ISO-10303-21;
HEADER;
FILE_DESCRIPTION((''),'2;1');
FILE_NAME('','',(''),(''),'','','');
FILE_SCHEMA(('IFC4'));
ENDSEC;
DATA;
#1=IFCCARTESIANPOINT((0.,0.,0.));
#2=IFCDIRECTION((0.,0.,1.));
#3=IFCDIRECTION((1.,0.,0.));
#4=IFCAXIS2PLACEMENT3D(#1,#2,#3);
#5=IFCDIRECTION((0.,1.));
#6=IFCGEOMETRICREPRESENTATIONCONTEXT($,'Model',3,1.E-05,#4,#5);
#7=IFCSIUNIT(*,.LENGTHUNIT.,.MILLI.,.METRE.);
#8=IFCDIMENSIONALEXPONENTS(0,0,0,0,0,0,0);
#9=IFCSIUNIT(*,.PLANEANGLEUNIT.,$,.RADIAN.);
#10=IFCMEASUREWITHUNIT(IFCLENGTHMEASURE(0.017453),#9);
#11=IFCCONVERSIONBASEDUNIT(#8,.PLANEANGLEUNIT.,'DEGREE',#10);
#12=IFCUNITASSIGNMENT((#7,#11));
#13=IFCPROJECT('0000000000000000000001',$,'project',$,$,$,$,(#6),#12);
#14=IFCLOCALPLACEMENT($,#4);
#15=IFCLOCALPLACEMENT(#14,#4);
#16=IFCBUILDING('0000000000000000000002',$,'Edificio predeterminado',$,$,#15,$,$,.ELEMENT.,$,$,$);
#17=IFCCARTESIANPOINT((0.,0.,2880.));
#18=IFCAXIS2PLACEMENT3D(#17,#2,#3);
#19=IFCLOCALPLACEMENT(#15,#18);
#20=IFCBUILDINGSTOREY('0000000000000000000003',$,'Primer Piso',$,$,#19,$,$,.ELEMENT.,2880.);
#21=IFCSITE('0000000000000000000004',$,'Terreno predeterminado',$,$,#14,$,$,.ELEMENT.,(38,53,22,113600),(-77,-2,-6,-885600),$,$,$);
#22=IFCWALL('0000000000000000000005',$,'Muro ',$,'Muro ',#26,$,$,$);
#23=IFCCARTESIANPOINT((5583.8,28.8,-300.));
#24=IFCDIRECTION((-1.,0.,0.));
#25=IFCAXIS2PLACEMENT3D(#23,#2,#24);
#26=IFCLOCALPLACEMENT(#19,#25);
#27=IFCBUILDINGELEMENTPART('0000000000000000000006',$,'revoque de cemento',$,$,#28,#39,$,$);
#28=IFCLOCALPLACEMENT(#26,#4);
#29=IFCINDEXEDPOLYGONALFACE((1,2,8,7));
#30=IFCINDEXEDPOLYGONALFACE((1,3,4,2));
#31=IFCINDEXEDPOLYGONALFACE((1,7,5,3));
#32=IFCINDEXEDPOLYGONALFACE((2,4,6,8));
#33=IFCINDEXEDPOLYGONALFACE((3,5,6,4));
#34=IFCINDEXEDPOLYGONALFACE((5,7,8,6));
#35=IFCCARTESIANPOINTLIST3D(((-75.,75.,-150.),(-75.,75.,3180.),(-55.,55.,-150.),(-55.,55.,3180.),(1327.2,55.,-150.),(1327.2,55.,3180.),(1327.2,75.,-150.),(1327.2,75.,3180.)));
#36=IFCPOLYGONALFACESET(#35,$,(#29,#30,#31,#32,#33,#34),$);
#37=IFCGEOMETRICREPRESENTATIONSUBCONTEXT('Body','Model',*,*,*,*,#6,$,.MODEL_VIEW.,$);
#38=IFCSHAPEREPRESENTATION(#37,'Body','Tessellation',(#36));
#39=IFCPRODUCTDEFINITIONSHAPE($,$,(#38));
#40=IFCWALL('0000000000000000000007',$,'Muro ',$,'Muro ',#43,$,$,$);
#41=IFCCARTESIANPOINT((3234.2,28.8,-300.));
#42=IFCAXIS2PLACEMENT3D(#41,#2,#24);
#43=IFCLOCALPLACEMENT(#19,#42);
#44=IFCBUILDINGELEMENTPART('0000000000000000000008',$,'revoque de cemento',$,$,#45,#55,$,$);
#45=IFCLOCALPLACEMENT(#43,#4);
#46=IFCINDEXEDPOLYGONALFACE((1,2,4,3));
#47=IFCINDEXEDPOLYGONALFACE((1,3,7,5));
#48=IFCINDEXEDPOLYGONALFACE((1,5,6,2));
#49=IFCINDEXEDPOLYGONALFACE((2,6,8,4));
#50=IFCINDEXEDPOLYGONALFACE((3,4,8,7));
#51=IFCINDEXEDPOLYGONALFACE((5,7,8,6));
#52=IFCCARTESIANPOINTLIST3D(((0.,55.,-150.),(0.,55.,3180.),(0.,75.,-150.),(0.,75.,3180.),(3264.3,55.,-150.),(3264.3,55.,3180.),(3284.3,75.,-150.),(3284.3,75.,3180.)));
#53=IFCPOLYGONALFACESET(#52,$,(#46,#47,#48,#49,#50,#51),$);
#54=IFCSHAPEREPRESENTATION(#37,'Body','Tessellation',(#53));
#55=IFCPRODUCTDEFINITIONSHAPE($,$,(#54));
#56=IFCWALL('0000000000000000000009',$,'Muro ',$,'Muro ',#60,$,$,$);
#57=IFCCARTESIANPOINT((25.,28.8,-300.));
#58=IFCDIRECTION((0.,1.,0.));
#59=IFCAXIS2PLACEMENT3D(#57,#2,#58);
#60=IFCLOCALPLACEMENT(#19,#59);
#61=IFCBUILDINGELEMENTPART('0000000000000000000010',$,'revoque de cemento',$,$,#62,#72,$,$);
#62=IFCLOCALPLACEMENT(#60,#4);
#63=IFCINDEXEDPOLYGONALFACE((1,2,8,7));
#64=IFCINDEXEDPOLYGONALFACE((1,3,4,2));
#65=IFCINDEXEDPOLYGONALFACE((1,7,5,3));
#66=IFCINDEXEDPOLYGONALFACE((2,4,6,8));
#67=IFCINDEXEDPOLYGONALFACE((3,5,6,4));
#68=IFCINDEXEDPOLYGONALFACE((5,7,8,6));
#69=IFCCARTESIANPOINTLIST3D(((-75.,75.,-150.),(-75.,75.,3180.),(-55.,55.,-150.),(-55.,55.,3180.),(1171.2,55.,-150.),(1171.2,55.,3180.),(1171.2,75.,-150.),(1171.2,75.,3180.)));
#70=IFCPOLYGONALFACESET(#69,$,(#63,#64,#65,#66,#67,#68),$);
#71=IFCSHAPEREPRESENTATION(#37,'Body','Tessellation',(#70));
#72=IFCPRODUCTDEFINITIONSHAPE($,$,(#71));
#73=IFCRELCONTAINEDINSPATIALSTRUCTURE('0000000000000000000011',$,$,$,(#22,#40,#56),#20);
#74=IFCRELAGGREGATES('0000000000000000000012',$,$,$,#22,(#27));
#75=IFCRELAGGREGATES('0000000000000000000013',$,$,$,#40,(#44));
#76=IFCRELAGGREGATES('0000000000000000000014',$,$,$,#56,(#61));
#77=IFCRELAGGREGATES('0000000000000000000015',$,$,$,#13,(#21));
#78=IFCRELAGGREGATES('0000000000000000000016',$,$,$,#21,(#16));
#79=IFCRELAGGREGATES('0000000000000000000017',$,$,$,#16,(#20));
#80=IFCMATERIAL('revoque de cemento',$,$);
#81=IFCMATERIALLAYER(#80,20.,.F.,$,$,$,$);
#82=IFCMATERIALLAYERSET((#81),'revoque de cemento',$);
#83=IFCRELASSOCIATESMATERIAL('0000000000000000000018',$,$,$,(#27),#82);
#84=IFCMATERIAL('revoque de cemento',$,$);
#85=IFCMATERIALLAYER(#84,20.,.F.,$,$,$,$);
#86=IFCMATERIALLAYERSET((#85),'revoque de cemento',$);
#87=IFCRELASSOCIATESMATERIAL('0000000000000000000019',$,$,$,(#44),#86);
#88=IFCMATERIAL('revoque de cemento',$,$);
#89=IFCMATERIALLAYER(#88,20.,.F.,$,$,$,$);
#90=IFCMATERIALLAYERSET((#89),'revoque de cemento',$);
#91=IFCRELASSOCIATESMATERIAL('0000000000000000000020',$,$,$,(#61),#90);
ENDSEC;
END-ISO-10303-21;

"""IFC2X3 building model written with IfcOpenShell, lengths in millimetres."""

from ifc_helpers import new_model, entity, si_unit, converted_unit, direction, frame, origin_with_axes, place, context, subcontext, project, spatial, polyline, outline, extrude, clip, bounded_halfspace, material, layer, layer_set, layer_usage, element, aggregate, save


model = new_model("IFC2X3")

# Units and contexts
model_context = context("Model", 3, precision=1e-05, world=origin_with_axes(), true_north=direction((0.0, 1.0)))
body_context = subcontext(model_context, "Body", "Model", "MODEL_VIEW")
ifc_project = project(units=[si_unit("LENGTHUNIT", "METRE", prefix="MILLI"), converted_unit("PLANEANGLEUNIT", "DEGREE", entity("IfcLengthMeasure", 0.017453), si_unit("PLANEANGLEUNIT", "RADIAN"), dimensions=[0, 0, 0, 0, 0, 0, 0])], contexts=[model_context])

# Site, building, storey
site_placement = place(None, origin_with_axes())
site = spatial("IfcSite", under=ifc_project, at=site_placement, Name="Terreno predeterminado", CompositionType="ELEMENT", RefLatitude=(38, 53, 22, 113600), RefLongitude=(-77, -2, -6, -885600))
building_placement = place(site_placement, origin_with_axes())
building = spatial("IfcBuilding", under=site, at=building_placement, Name="Edificio predeterminado", CompositionType="ELEMENT")
storey_placement = place(building_placement, frame((0.0, 0.0, 2880.0), z_axis=(0.0, 0.0, 1.0), x_axis=(1.0, 0.0, 0.0)))
storey = spatial("IfcBuildingStorey", under=building, at=storey_placement, Name="Primer Piso", CompositionType="ELEMENT", Elevation=2880.0)

# Walls, building element parts
wall_1_placement = place(storey_placement, frame((5583.8, 28.8, -300.0), z_axis=(0.0, 0.0, 1.0), x_axis=(-1.0, 0.0, 0.0)))
wall_1 = element("IfcWall", 1, at=wall_1_placement, inside=storey, Name="Muro ", ObjectType="Muro ")
ifc_material_1 = material(Name="revoque de cemento")
ifc_layer_1 = layer(ifc_material_1, 20.0, ventilated=False)
ifc_layer_set_1 = layer_set([ifc_layer_1], Name="revoque de cemento")
ifc_layer_usage_1 = layer_usage(ifc_layer_set_1, "AXIS2", "NEGATIVE", -75.0)
building_element_part_1_placement = place(wall_1_placement, origin_with_axes())
building_element_part_1 = element("IfcBuildingElementPart", 2, at=building_element_part_1_placement, material=ifc_layer_usage_1, Name="revoque de cemento", context=body_context, shape_type="Clipping", body=[
    clip(clip(extrude(outline(polyline([(1327.2, 75.0), (1327.2, 55.0), (-55.0, 55.0), (-75.0, 75.0), (1327.2, 75.0)])), frame((0.0, 0.0, -150.0), z_axis=(0.0, 0.0, 1.0), x_axis=(1.0, 0.0, 0.0)), (0.0, 0.0, 1.0), 3330.0), bounded_halfspace(frame((0.0, 0.0, -150.0), z_axis=(0.0, 0.0, 1.0), x_axis=(1.0, 0.0, 0.0)), True, origin_with_axes(), polyline([(-150.0, -150.0), (1582.2, -150.0), (1582.2, 150.0), (-150.0, 150.0), (-150.0, -150.0)]))), bounded_halfspace(frame((0.0, 0.0, 3180.0), z_axis=(0.0, 0.0, 1.0), x_axis=(1.0, 0.0, 0.0)), False, origin_with_axes(), polyline([(-150.0, -150.0), (1582.2, -150.0), (1582.2, 150.0), (-150.0, 150.0), (-150.0, -150.0)]))),
])
aggregate(wall_1, [building_element_part_1])
wall_2_placement = place(storey_placement, frame((3234.2, 28.8, -300.0), z_axis=(0.0, 0.0, 1.0), x_axis=(-1.0, 0.0, 0.0)))
wall_2 = element("IfcWall", 3, at=wall_2_placement, inside=storey, Name="Muro ", ObjectType="Muro ")
ifc_material_2 = material(Name="revoque de cemento")
ifc_layer_2 = layer(ifc_material_2, 20.0, ventilated=False)
ifc_layer_set_2 = layer_set([ifc_layer_2], Name="revoque de cemento")
ifc_layer_usage_2 = layer_usage(ifc_layer_set_2, "AXIS2", "NEGATIVE", -75.0)
building_element_part_2_placement = place(wall_2_placement, origin_with_axes())
building_element_part_2 = element("IfcBuildingElementPart", 4, at=building_element_part_2_placement, material=ifc_layer_usage_2, Name="revoque de cemento", context=body_context, shape_type="Clipping", body=[
    clip(clip(extrude(outline(polyline([(3284.2, 75.0), (3264.2, 55.0), (0.0, 55.0), (0.0, 75.0), (3284.2, 75.0)])), frame((0.0, 0.0, -150.0), z_axis=(0.0, 0.0, 1.0), x_axis=(1.0, 0.0, 0.0)), (0.0, 0.0, 1.0), 3330.0), bounded_halfspace(frame((0.0, 0.0, -150.0), z_axis=(0.0, 0.0, 1.0), x_axis=(1.0, 0.0, 0.0)), True, origin_with_axes(), polyline([(-150.0, -150.0), (3359.2, -150.0), (3359.2, 150.0), (-150.0, 150.0), (-150.0, -150.0)]))), bounded_halfspace(frame((0.0, 0.0, 3180.0), z_axis=(0.0, 0.0, 1.0), x_axis=(1.0, 0.0, 0.0)), False, origin_with_axes(), polyline([(-150.0, -150.0), (3359.2, -150.0), (3359.2, 150.0), (-150.0, 150.0), (-150.0, -150.0)]))),
])
aggregate(wall_2, [building_element_part_2])
wall_3_placement = place(storey_placement, frame((25.0, 28.8, -300.0), z_axis=(0.0, 0.0, 1.0), x_axis=(0.0, 1.0, 0.0)))
wall_3 = element("IfcWall", 5, at=wall_3_placement, inside=storey, Name="Muro ", ObjectType="Muro ")
ifc_material_3 = material(Name="revoque de cemento")
ifc_layer_3 = layer(ifc_material_3, 20.0, ventilated=False)
ifc_layer_set_3 = layer_set([ifc_layer_3], Name="revoque de cemento")
ifc_layer_usage_3 = layer_usage(ifc_layer_set_3, "AXIS2", "NEGATIVE", -75.0)
building_element_part_3_placement = place(wall_3_placement, origin_with_axes())
building_element_part_3 = element("IfcBuildingElementPart", 6, at=building_element_part_3_placement, material=ifc_layer_usage_3, Name="revoque de cemento", context=body_context, shape_type="Clipping", body=[
    clip(clip(extrude(outline(polyline([(1171.2, 75.0), (1171.2, 55.0), (55.0, 55.0), (-55.0, 55.0), (-75.0, 75.0), (1171.2, 75.0)])), frame((0.0, 0.0, -150.0), z_axis=(0.0, 0.0, 1.0), x_axis=(1.0, 0.0, 0.0)), (0.0, 0.0, 1.0), 3330.0), bounded_halfspace(frame((0.0, 0.0, -150.0), z_axis=(0.0, 0.0, 1.0), x_axis=(1.0, 0.0, 0.0)), True, origin_with_axes(), polyline([(-150.0, -150.0), (1321.2, -150.0), (1321.2, 150.0), (-150.0, 150.0), (-150.0, -150.0)]))), bounded_halfspace(frame((0.0, 0.0, 3180.0), z_axis=(0.0, 0.0, 1.0), x_axis=(1.0, 0.0, 0.0)), False, origin_with_axes(), polyline([(-150.0, -150.0), (1321.2, -150.0), (1321.2, 150.0), (-150.0, 150.0), (-150.0, -150.0)]))),
])
aggregate(wall_3, [building_element_part_3])

save(model, "model.ifc")
